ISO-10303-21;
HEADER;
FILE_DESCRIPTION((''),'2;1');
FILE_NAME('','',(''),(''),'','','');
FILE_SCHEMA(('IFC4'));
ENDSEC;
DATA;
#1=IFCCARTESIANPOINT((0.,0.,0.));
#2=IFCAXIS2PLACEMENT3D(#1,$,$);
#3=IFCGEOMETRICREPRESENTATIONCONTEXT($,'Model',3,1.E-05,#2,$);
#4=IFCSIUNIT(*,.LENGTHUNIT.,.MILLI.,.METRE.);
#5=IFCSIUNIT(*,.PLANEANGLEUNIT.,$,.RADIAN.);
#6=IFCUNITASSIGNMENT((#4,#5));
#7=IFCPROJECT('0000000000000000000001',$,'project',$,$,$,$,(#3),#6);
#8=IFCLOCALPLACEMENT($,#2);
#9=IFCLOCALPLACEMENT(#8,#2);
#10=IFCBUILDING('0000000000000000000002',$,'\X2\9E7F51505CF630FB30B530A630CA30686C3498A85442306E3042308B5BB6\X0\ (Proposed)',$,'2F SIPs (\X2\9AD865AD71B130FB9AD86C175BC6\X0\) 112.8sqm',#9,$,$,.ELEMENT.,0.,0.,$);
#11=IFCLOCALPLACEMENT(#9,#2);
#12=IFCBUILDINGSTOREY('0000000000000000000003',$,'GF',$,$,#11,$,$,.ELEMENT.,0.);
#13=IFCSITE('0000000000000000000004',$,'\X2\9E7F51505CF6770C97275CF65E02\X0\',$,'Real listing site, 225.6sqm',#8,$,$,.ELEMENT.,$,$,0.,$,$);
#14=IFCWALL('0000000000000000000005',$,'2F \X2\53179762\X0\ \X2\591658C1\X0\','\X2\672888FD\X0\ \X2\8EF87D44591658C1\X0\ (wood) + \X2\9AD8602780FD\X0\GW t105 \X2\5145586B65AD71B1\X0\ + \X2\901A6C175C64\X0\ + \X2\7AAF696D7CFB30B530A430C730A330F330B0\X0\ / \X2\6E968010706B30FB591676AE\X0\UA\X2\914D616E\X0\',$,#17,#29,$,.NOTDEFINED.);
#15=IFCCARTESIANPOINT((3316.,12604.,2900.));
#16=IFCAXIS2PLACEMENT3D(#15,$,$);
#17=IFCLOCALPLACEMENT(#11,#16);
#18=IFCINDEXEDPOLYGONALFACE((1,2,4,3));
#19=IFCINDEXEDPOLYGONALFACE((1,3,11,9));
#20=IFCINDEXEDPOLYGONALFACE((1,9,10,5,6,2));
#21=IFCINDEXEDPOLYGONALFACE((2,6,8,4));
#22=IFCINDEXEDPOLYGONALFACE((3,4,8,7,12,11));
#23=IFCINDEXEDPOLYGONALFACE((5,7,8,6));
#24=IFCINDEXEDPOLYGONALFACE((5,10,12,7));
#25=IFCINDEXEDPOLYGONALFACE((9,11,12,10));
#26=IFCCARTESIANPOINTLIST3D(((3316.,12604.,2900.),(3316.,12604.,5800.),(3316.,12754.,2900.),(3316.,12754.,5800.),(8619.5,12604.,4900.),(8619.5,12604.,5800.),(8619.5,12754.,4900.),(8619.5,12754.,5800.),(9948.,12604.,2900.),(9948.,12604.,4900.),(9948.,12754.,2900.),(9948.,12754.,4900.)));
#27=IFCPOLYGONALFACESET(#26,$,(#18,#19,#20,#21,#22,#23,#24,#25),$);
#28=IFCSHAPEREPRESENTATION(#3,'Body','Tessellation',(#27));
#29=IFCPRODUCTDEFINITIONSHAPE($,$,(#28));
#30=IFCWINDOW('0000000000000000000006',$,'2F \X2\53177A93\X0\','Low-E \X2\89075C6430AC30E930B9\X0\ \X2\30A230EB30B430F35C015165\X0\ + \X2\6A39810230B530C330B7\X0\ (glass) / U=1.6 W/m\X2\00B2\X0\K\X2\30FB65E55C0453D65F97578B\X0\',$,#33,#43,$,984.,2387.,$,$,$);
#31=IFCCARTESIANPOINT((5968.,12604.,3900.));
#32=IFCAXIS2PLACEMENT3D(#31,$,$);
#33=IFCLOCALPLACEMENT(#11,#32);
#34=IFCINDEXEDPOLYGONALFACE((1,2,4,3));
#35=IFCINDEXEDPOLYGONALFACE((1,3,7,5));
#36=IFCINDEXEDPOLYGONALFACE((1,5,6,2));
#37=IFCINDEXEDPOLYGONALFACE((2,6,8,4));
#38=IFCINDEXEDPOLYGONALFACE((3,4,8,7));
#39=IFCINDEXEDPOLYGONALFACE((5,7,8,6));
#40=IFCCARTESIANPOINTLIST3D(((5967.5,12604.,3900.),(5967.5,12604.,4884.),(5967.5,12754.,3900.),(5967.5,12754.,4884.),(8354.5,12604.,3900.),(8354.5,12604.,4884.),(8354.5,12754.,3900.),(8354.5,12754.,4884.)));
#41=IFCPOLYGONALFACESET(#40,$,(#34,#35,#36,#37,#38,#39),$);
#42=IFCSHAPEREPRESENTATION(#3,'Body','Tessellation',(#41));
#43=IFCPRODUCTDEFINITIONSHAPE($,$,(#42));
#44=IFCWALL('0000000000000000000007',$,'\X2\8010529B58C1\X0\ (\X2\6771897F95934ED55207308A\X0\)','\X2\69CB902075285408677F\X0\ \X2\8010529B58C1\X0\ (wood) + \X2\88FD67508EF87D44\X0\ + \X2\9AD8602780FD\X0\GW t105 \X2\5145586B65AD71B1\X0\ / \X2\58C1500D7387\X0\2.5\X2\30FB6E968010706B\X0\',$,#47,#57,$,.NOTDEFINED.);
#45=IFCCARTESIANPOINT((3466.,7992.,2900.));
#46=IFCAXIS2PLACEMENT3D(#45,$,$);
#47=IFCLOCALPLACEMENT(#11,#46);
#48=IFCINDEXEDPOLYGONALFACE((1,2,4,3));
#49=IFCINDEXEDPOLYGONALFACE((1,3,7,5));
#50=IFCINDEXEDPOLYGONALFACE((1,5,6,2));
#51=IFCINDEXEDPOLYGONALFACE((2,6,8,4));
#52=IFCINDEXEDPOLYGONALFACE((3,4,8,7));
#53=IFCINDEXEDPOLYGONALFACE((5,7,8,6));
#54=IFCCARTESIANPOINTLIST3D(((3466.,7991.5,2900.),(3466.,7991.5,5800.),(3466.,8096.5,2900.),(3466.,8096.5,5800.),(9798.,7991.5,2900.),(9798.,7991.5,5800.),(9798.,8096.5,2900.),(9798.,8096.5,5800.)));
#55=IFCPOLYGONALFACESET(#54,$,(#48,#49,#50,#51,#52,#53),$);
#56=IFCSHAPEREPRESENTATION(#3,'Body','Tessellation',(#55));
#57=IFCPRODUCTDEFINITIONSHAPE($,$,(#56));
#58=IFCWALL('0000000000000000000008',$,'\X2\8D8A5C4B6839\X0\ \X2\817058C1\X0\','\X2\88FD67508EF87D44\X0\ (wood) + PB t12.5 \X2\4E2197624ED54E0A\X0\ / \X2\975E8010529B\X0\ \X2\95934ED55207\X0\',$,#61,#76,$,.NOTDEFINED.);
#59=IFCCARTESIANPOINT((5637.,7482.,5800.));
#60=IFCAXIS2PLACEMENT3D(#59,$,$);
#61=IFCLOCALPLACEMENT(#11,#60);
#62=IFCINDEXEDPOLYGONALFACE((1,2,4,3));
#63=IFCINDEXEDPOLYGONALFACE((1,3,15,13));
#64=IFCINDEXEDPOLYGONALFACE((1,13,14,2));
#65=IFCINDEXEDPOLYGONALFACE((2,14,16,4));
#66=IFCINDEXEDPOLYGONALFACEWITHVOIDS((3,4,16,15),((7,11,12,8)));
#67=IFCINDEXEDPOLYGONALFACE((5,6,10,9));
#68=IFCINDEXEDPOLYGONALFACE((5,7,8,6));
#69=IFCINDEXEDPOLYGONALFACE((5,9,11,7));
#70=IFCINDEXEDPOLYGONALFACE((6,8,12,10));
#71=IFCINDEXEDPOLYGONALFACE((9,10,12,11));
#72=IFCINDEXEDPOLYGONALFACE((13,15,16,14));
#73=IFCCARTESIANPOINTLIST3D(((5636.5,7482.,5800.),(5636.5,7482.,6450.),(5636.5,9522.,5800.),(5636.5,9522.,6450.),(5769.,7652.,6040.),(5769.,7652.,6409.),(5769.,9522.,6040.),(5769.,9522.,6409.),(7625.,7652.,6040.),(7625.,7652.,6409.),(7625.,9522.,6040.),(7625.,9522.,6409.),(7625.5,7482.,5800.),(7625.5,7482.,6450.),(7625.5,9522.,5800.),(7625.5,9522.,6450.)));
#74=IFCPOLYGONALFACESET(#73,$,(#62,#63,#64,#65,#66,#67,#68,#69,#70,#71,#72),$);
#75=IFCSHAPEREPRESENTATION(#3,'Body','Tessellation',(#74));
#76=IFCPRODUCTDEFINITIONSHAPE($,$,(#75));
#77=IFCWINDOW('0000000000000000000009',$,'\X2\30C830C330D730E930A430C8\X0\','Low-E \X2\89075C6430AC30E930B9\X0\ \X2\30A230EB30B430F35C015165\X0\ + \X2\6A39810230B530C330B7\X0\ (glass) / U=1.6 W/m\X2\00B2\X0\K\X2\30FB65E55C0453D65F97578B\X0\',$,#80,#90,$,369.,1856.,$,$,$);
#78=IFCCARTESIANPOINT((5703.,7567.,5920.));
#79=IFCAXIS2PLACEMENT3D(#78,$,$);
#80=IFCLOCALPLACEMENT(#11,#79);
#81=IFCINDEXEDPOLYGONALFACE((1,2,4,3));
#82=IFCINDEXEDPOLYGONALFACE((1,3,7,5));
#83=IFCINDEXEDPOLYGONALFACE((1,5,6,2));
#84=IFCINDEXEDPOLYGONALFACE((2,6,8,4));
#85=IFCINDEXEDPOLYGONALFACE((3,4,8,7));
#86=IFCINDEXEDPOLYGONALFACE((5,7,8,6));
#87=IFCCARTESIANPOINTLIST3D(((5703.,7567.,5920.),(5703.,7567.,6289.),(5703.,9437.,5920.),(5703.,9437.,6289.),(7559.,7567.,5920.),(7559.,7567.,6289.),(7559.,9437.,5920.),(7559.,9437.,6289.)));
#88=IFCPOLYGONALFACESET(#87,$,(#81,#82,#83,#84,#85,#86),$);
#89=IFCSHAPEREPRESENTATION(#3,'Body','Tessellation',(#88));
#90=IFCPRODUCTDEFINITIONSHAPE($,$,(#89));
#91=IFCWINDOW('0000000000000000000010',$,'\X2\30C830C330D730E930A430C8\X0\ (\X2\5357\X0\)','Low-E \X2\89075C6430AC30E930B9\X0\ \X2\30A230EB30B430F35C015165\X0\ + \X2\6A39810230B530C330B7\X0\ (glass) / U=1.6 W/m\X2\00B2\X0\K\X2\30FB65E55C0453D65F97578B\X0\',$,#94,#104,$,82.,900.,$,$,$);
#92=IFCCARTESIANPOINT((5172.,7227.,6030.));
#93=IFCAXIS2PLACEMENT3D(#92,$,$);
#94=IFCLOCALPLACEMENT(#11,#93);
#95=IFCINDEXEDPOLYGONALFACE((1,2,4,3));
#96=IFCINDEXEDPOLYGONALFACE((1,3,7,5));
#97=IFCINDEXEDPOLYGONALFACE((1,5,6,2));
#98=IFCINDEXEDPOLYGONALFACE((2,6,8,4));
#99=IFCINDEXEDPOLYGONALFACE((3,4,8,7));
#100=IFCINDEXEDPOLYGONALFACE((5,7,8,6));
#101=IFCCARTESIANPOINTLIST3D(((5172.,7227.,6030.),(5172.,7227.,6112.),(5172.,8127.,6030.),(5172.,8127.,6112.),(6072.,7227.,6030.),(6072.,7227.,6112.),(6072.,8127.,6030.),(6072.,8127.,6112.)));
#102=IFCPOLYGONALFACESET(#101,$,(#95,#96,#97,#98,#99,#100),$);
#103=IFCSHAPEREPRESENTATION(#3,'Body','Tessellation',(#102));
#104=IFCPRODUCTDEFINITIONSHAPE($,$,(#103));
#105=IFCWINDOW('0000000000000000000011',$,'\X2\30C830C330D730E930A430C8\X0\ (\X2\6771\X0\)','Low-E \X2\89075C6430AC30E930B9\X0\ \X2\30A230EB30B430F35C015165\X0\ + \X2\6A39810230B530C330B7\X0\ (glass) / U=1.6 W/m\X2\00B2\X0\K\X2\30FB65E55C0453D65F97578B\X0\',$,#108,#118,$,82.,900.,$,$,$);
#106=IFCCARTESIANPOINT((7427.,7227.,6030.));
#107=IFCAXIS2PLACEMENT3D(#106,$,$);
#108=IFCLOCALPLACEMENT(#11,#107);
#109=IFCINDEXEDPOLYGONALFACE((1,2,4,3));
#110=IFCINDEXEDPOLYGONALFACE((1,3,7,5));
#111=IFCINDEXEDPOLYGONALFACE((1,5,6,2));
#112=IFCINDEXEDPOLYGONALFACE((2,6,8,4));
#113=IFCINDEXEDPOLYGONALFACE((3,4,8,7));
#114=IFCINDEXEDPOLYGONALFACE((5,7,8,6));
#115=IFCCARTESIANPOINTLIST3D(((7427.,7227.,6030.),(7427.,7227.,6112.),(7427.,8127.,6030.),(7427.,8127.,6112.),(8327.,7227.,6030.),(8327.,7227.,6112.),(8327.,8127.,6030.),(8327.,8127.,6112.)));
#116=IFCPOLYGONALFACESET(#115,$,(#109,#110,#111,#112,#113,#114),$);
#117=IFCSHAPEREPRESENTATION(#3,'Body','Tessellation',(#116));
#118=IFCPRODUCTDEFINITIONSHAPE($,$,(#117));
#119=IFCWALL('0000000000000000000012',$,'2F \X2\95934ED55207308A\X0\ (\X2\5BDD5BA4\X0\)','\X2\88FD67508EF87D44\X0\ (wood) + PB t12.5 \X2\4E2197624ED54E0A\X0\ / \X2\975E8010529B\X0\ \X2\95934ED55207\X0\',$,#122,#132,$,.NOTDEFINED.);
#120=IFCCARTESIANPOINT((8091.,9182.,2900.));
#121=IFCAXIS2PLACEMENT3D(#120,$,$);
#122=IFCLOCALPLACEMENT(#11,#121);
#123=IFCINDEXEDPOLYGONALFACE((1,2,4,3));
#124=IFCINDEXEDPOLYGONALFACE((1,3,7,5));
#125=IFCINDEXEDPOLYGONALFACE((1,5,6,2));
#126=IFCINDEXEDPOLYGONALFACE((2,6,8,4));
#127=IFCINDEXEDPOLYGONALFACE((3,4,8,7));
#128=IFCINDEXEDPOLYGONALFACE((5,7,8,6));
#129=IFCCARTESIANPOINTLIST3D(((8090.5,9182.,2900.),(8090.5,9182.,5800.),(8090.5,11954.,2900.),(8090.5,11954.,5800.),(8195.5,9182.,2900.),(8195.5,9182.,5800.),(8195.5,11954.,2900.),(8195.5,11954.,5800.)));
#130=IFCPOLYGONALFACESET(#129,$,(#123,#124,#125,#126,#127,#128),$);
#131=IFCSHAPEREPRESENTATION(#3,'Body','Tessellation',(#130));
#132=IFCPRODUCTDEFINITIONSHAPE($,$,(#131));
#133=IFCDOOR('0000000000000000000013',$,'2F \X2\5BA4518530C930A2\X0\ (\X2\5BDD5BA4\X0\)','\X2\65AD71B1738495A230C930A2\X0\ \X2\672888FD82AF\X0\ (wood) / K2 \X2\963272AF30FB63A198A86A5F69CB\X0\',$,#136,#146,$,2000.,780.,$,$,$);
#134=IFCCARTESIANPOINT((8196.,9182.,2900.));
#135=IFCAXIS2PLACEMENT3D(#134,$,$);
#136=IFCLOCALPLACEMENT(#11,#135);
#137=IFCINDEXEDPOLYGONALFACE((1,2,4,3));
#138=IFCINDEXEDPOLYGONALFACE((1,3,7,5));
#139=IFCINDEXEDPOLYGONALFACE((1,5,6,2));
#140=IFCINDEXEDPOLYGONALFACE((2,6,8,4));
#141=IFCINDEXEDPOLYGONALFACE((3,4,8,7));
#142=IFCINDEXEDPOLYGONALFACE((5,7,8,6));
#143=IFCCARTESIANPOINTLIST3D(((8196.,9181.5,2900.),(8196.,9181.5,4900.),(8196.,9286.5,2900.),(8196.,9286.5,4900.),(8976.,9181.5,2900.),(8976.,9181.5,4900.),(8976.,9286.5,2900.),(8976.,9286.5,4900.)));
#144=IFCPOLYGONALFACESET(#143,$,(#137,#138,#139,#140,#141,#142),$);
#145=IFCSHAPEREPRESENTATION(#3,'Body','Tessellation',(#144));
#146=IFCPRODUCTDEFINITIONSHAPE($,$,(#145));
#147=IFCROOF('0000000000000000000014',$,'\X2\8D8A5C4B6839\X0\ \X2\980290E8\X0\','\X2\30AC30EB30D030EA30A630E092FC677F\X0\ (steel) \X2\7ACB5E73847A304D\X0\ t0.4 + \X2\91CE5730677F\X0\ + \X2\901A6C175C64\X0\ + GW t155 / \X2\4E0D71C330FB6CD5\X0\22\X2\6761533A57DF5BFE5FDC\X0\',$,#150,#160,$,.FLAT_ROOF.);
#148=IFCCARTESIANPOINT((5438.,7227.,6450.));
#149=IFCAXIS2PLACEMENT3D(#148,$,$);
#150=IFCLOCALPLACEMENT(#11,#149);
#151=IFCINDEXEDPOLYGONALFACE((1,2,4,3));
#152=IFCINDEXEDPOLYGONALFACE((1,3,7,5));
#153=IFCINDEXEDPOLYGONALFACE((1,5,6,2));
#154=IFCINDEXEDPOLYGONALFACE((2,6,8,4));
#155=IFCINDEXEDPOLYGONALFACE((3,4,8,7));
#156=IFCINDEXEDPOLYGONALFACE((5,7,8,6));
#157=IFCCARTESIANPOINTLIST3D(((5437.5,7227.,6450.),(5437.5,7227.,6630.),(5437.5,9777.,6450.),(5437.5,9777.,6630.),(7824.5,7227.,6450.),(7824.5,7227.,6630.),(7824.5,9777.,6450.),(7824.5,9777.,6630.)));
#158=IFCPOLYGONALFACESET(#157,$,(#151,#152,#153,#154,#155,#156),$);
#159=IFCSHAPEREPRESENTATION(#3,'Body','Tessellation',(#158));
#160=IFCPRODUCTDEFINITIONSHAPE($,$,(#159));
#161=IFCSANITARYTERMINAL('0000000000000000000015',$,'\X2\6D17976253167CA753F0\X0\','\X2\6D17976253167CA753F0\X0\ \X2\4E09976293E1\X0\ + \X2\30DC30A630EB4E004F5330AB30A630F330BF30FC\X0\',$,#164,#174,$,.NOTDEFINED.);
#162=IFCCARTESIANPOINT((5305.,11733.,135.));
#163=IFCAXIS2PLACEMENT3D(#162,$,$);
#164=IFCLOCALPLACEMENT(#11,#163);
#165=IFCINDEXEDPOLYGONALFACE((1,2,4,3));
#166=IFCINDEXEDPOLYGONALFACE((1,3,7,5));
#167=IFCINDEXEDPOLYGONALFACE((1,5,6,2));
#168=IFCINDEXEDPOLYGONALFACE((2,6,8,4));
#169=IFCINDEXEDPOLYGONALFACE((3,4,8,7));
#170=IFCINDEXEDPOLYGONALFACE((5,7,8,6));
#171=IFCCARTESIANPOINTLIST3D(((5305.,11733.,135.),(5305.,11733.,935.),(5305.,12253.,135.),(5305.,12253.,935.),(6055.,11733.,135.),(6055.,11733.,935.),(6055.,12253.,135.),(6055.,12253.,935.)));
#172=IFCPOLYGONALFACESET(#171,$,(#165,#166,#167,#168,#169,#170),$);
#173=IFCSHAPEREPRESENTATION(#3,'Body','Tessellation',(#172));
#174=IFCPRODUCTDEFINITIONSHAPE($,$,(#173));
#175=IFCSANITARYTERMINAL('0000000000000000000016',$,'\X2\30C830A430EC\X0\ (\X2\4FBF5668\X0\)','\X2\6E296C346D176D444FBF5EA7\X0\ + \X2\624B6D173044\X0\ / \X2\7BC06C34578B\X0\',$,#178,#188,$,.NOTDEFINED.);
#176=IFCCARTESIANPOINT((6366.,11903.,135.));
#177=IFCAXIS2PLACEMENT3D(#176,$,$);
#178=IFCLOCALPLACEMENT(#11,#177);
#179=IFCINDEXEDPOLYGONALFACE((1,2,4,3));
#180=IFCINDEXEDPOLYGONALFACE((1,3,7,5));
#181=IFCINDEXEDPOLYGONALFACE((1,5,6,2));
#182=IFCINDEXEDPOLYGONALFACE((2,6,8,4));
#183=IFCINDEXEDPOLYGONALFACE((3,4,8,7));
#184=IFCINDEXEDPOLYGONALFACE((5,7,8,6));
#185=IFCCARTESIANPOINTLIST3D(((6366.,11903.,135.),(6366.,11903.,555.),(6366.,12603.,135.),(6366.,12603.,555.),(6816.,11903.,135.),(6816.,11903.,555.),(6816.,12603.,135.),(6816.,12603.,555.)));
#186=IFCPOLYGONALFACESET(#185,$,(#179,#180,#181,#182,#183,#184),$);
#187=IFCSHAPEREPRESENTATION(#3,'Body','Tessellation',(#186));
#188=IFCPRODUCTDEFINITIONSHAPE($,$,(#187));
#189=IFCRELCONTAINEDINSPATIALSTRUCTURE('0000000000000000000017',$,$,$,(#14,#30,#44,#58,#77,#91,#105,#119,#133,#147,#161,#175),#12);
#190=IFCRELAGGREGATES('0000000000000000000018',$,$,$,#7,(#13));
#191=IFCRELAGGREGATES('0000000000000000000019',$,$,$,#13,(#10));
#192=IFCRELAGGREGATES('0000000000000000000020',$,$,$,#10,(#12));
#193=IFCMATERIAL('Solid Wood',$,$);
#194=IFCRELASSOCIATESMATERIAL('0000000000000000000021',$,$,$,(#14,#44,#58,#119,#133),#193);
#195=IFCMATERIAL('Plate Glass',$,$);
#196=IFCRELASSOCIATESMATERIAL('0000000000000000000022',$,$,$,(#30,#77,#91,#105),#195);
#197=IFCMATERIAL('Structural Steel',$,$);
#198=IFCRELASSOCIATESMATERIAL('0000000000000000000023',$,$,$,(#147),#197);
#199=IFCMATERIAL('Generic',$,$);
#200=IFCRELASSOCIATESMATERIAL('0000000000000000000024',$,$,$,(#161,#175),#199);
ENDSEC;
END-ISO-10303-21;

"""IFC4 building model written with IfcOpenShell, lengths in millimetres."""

from ifc_helpers import new_model, si_unit, frame, frame_2d, origin, place, context, project, spatial, rectangle, extrude, material, element, fill, save


model = new_model("IFC4")

# Units and contexts
model_context = context("Model", 3, precision=1e-05, world=origin())
ifc_project = project(units=[si_unit("LENGTHUNIT", "METRE", prefix="MILLI"), si_unit("PLANEANGLEUNIT", "RADIAN")], contexts=[model_context])

# Site, building, storey
site_placement = place(None, origin())
site = spatial("IfcSite", under=ifc_project, at=site_placement, Name="鹿児島県霧島市", ObjectType="Real listing site, 225.6sqm", CompositionType="ELEMENT", RefElevation=0.0)
building_placement = place(site_placement, origin())
building = spatial("IfcBuilding", under=site, at=building_placement, Name="鹿児島・サウナと水風呂のある家 (Proposed)", ObjectType="2F SIPs (高断熱・高気密) 112.8sqm", CompositionType="ELEMENT", ElevationOfRefHeight=0.0, ElevationOfTerrain=0.0)
storey_placement = place(building_placement, origin())
storey = spatial("IfcBuildingStorey", under=building, at=storey_placement, Name="GF", CompositionType="ELEMENT", Elevation=0.0)

# Wall, opening, window
ifc_material_1 = material(Name="Solid Wood")
wall_1_placement = place(storey_placement, frame((3316.0, 12604.0, 2900.0)))
wall_1 = element("IfcWall", 1, at=wall_1_placement, inside=storey, material=ifc_material_1, Name="2F 北面 外壁", Description="木製 軸組外壁 (wood) + 高性能GW t105 充填断熱 + 通気層 + 窯業系サイディング / 準耐火・外皮UA配慮", PredefinedType="NOTDEFINED", context=model_context, shape_type="SweptSolid", body=[
    extrude(rectangle(XDim=6632.0, YDim=150.0, at=frame_2d((3316.0, 75.0))), frame((3316.0, 12604.0, 2900.0)), (0.0, 0.0, 1.0), 2900.0),
])
opening_1_placement = place(storey_placement, frame((5968.0, 12604.0, 3900.0)))
opening_1 = element("IfcOpeningElement", 2, at=opening_1_placement, cuts=wall_1, PredefinedType="NOTDEFINED", context=model_context, shape_type="SweptSolid", body=[
    extrude(rectangle(XDim=2387.0, YDim=150.0, at=frame_2d((1193.0, 75.0))), frame((5968.0, 12604.0, 3900.0)), (0.0, 0.0, 1.0), 984.0),
])
ifc_material_2 = material(Name="Plate Glass")
window_1_placement = place(storey_placement, frame((5968.0, 12604.0, 3900.0)))
window_1 = element("IfcWindow", 3, at=window_1_placement, inside=storey, material=ifc_material_2, Name="2F 北窓", Description="Low-E 複層ガラス アルゴン封入 + 樹脂サッシ (glass) / U=1.6 W/m²K・日射取得型", OverallHeight=984.0, OverallWidth=2387.0, context=model_context, shape_type="SweptSolid", body=[
    extrude(rectangle(XDim=2387.0, YDim=150.0, at=frame_2d((1193.0, 75.0))), frame((5968.0, 12604.0, 3900.0)), (0.0, 0.0, 1.0), 984.0),
])
fill(opening_1, window_1)

# Wall
wall_2_placement = place(storey_placement, frame((3466.0, 7992.0, 2900.0)))
element("IfcWall", 4, at=wall_2_placement, inside=storey, material=ifc_material_1, Name="耐力壁 (東西間仕切り)", Description="構造用合板 耐力壁 (wood) + 製材軸組 + 高性能GW t105 充填断熱 / 壁倍率2.5・準耐火", PredefinedType="NOTDEFINED", context=model_context, shape_type="SweptSolid", body=[
    extrude(rectangle(XDim=6332.0, YDim=105.0, at=frame_2d((3166.0, 52.0))), frame((3466.0, 7992.0, 2900.0)), (0.0, 0.0, 1.0), 2900.0),
])

# Wall, openings, windows
wall_3_placement = place(storey_placement, frame((5637.0, 7482.0, 5800.0)))
wall_3 = element("IfcWall", 5, at=wall_3_placement, inside=storey, material=ifc_material_1, Name="越屋根 腰壁", Description="製材軸組 (wood) + PB t12.5 両面仕上 / 非耐力 間仕切", PredefinedType="NOTDEFINED", context=model_context, shape_type="SweptSolid", body=[
    extrude(rectangle(XDim=1989.0, YDim=2040.0, at=frame_2d((994.0, 1020.0))), frame((5637.0, 7482.0, 5800.0)), (0.0, 0.0, 1.0), 650.0),
])
opening_2_placement = place(storey_placement, frame((5703.0, 7567.0, 5920.0)))
opening_2 = element("IfcOpeningElement", 6, at=opening_2_placement, cuts=wall_3, PredefinedType="NOTDEFINED", context=model_context, shape_type="SweptSolid", body=[
    extrude(rectangle(XDim=1856.0, YDim=1870.0, at=frame_2d((928.0, 935.0))), frame((5703.0, 7567.0, 5920.0)), (0.0, 0.0, 1.0), 369.0),
])
opening_3_placement = place(storey_placement, frame((5172.0, 7227.0, 6030.0)))
opening_3 = element("IfcOpeningElement", 7, at=opening_3_placement, cuts=wall_3, PredefinedType="NOTDEFINED", context=model_context, shape_type="SweptSolid", body=[
    extrude(rectangle(XDim=900.0, YDim=900.0, at=frame_2d((450.0, 450.0))), frame((5172.0, 7227.0, 6030.0)), (0.0, 0.0, 1.0), 82.0),
])
opening_4_placement = place(storey_placement, frame((7427.0, 7227.0, 6030.0)))
opening_4 = element("IfcOpeningElement", 8, at=opening_4_placement, cuts=wall_3, PredefinedType="NOTDEFINED", context=model_context, shape_type="SweptSolid", body=[
    extrude(rectangle(XDim=900.0, YDim=900.0, at=frame_2d((450.0, 450.0))), frame((7427.0, 7227.0, 6030.0)), (0.0, 0.0, 1.0), 82.0),
])
window_2_placement = place(storey_placement, frame((5703.0, 7567.0, 5920.0)))
window_2 = element("IfcWindow", 9, at=window_2_placement, inside=storey, material=ifc_material_2, Name="トップライト", Description="Low-E 複層ガラス アルゴン封入 + 樹脂サッシ (glass) / U=1.6 W/m²K・日射取得型", OverallHeight=369.0, OverallWidth=1856.0, context=model_context, shape_type="SweptSolid", body=[
    extrude(rectangle(XDim=1856.0, YDim=1870.0, at=frame_2d((928.0, 935.0))), frame((5703.0, 7567.0, 5920.0)), (0.0, 0.0, 1.0), 369.0),
])
fill(opening_2, window_2)
window_3_placement = place(storey_placement, frame((5172.0, 7227.0, 6030.0)))
window_3 = element("IfcWindow", 10, at=window_3_placement, inside=storey, material=ifc_material_2, Name="トップライト (南)", Description="Low-E 複層ガラス アルゴン封入 + 樹脂サッシ (glass) / U=1.6 W/m²K・日射取得型", OverallHeight=82.0, OverallWidth=900.0, context=model_context, shape_type="SweptSolid", body=[
    extrude(rectangle(XDim=900.0, YDim=900.0, at=frame_2d((450.0, 450.0))), frame((5172.0, 7227.0, 6030.0)), (0.0, 0.0, 1.0), 82.0),
])
fill(opening_3, window_3)
window_4_placement = place(storey_placement, frame((7427.0, 7227.0, 6030.0)))
window_4 = element("IfcWindow", 11, at=window_4_placement, inside=storey, material=ifc_material_2, Name="トップライト (東)", Description="Low-E 複層ガラス アルゴン封入 + 樹脂サッシ (glass) / U=1.6 W/m²K・日射取得型", OverallHeight=82.0, OverallWidth=900.0, context=model_context, shape_type="SweptSolid", body=[
    extrude(rectangle(XDim=900.0, YDim=900.0, at=frame_2d((450.0, 450.0))), frame((7427.0, 7227.0, 6030.0)), (0.0, 0.0, 1.0), 82.0),
])
fill(opening_4, window_4)

# Wall
wall_4_placement = place(storey_placement, frame((8091.0, 9182.0, 2900.0)))
element("IfcWall", 12, at=wall_4_placement, inside=storey, material=ifc_material_1, Name="2F 間仕切り (寝室)", Description="製材軸組 (wood) + PB t12.5 両面仕上 / 非耐力 間仕切", PredefinedType="NOTDEFINED", context=model_context, shape_type="SweptSolid", body=[
    extrude(rectangle(XDim=105.0, YDim=2772.0, at=frame_2d((52.0, 1386.0))), frame((8091.0, 9182.0, 2900.0)), (0.0, 0.0, 1.0), 2900.0),
])

# Door
door_placement = place(storey_placement, frame((8196.0, 9182.0, 2900.0)))
element("IfcDoor", 13, at=door_placement, inside=storey, material=ifc_material_1, Name="2F 室内ドア (寝室)", Description="断熱玄関ドア 木製芯 (wood) / K2 防犯・採風機構", OverallHeight=2000.0, OverallWidth=780.0, context=model_context, shape_type="SweptSolid", body=[
    extrude(rectangle(XDim=780.0, YDim=105.0, at=frame_2d((390.0, 52.0))), frame((8196.0, 9182.0, 2900.0)), (0.0, 0.0, 1.0), 2000.0),
])

# Roof
ifc_material_3 = material(Name="Structural Steel")
roof_placement = place(storey_placement, frame((5438.0, 7227.0, 6450.0)))
element("IfcRoof", 14, at=roof_placement, inside=storey, material=ifc_material_3, Name="越屋根 頂部", Description="ガルバリウム鋼板 (steel) 立平葺き t0.4 + 野地板 + 通気層 + GW t155 / 不燃・法22条区域対応", PredefinedType="FLAT_ROOF", context=model_context, shape_type="SweptSolid", body=[
    extrude(rectangle(XDim=2387.0, YDim=2550.0, at=frame_2d((1193.0, 1275.0))), frame((5438.0, 7227.0, 6450.0)), (0.0, 0.0, 1.0), 180.0),
])

# Sanitary terminals
ifc_material_4 = material(Name="Generic")
sanitary_terminal_1_placement = place(storey_placement, frame((5305.0, 11733.0, 135.0)))
element("IfcSanitaryTerminal", 15, at=sanitary_terminal_1_placement, inside=storey, material=ifc_material_4, Name="洗面化粧台", Description="洗面化粧台 三面鏡 + ボウル一体カウンター", PredefinedType="NOTDEFINED", context=model_context, shape_type="SweptSolid", body=[
    extrude(rectangle(XDim=750.0, YDim=520.0, at=frame_2d((375.0, 260.0))), frame((5305.0, 11733.0, 135.0)), (0.0, 0.0, 1.0), 800.0),
])
sanitary_terminal_2_placement = place(storey_placement, frame((6366.0, 11903.0, 135.0)))
element("IfcSanitaryTerminal", 16, at=sanitary_terminal_2_placement, inside=storey, material=ifc_material_4, Name="トイレ (便器)", Description="温水洗浄便座 + 手洗い / 節水型", PredefinedType="NOTDEFINED", context=model_context, shape_type="SweptSolid", body=[
    extrude(rectangle(XDim=450.0, YDim=700.0, at=frame_2d((225.0, 350.0))), frame((6366.0, 11903.0, 135.0)), (0.0, 0.0, 1.0), 420.0),
])

save(model, "model.ifc")
